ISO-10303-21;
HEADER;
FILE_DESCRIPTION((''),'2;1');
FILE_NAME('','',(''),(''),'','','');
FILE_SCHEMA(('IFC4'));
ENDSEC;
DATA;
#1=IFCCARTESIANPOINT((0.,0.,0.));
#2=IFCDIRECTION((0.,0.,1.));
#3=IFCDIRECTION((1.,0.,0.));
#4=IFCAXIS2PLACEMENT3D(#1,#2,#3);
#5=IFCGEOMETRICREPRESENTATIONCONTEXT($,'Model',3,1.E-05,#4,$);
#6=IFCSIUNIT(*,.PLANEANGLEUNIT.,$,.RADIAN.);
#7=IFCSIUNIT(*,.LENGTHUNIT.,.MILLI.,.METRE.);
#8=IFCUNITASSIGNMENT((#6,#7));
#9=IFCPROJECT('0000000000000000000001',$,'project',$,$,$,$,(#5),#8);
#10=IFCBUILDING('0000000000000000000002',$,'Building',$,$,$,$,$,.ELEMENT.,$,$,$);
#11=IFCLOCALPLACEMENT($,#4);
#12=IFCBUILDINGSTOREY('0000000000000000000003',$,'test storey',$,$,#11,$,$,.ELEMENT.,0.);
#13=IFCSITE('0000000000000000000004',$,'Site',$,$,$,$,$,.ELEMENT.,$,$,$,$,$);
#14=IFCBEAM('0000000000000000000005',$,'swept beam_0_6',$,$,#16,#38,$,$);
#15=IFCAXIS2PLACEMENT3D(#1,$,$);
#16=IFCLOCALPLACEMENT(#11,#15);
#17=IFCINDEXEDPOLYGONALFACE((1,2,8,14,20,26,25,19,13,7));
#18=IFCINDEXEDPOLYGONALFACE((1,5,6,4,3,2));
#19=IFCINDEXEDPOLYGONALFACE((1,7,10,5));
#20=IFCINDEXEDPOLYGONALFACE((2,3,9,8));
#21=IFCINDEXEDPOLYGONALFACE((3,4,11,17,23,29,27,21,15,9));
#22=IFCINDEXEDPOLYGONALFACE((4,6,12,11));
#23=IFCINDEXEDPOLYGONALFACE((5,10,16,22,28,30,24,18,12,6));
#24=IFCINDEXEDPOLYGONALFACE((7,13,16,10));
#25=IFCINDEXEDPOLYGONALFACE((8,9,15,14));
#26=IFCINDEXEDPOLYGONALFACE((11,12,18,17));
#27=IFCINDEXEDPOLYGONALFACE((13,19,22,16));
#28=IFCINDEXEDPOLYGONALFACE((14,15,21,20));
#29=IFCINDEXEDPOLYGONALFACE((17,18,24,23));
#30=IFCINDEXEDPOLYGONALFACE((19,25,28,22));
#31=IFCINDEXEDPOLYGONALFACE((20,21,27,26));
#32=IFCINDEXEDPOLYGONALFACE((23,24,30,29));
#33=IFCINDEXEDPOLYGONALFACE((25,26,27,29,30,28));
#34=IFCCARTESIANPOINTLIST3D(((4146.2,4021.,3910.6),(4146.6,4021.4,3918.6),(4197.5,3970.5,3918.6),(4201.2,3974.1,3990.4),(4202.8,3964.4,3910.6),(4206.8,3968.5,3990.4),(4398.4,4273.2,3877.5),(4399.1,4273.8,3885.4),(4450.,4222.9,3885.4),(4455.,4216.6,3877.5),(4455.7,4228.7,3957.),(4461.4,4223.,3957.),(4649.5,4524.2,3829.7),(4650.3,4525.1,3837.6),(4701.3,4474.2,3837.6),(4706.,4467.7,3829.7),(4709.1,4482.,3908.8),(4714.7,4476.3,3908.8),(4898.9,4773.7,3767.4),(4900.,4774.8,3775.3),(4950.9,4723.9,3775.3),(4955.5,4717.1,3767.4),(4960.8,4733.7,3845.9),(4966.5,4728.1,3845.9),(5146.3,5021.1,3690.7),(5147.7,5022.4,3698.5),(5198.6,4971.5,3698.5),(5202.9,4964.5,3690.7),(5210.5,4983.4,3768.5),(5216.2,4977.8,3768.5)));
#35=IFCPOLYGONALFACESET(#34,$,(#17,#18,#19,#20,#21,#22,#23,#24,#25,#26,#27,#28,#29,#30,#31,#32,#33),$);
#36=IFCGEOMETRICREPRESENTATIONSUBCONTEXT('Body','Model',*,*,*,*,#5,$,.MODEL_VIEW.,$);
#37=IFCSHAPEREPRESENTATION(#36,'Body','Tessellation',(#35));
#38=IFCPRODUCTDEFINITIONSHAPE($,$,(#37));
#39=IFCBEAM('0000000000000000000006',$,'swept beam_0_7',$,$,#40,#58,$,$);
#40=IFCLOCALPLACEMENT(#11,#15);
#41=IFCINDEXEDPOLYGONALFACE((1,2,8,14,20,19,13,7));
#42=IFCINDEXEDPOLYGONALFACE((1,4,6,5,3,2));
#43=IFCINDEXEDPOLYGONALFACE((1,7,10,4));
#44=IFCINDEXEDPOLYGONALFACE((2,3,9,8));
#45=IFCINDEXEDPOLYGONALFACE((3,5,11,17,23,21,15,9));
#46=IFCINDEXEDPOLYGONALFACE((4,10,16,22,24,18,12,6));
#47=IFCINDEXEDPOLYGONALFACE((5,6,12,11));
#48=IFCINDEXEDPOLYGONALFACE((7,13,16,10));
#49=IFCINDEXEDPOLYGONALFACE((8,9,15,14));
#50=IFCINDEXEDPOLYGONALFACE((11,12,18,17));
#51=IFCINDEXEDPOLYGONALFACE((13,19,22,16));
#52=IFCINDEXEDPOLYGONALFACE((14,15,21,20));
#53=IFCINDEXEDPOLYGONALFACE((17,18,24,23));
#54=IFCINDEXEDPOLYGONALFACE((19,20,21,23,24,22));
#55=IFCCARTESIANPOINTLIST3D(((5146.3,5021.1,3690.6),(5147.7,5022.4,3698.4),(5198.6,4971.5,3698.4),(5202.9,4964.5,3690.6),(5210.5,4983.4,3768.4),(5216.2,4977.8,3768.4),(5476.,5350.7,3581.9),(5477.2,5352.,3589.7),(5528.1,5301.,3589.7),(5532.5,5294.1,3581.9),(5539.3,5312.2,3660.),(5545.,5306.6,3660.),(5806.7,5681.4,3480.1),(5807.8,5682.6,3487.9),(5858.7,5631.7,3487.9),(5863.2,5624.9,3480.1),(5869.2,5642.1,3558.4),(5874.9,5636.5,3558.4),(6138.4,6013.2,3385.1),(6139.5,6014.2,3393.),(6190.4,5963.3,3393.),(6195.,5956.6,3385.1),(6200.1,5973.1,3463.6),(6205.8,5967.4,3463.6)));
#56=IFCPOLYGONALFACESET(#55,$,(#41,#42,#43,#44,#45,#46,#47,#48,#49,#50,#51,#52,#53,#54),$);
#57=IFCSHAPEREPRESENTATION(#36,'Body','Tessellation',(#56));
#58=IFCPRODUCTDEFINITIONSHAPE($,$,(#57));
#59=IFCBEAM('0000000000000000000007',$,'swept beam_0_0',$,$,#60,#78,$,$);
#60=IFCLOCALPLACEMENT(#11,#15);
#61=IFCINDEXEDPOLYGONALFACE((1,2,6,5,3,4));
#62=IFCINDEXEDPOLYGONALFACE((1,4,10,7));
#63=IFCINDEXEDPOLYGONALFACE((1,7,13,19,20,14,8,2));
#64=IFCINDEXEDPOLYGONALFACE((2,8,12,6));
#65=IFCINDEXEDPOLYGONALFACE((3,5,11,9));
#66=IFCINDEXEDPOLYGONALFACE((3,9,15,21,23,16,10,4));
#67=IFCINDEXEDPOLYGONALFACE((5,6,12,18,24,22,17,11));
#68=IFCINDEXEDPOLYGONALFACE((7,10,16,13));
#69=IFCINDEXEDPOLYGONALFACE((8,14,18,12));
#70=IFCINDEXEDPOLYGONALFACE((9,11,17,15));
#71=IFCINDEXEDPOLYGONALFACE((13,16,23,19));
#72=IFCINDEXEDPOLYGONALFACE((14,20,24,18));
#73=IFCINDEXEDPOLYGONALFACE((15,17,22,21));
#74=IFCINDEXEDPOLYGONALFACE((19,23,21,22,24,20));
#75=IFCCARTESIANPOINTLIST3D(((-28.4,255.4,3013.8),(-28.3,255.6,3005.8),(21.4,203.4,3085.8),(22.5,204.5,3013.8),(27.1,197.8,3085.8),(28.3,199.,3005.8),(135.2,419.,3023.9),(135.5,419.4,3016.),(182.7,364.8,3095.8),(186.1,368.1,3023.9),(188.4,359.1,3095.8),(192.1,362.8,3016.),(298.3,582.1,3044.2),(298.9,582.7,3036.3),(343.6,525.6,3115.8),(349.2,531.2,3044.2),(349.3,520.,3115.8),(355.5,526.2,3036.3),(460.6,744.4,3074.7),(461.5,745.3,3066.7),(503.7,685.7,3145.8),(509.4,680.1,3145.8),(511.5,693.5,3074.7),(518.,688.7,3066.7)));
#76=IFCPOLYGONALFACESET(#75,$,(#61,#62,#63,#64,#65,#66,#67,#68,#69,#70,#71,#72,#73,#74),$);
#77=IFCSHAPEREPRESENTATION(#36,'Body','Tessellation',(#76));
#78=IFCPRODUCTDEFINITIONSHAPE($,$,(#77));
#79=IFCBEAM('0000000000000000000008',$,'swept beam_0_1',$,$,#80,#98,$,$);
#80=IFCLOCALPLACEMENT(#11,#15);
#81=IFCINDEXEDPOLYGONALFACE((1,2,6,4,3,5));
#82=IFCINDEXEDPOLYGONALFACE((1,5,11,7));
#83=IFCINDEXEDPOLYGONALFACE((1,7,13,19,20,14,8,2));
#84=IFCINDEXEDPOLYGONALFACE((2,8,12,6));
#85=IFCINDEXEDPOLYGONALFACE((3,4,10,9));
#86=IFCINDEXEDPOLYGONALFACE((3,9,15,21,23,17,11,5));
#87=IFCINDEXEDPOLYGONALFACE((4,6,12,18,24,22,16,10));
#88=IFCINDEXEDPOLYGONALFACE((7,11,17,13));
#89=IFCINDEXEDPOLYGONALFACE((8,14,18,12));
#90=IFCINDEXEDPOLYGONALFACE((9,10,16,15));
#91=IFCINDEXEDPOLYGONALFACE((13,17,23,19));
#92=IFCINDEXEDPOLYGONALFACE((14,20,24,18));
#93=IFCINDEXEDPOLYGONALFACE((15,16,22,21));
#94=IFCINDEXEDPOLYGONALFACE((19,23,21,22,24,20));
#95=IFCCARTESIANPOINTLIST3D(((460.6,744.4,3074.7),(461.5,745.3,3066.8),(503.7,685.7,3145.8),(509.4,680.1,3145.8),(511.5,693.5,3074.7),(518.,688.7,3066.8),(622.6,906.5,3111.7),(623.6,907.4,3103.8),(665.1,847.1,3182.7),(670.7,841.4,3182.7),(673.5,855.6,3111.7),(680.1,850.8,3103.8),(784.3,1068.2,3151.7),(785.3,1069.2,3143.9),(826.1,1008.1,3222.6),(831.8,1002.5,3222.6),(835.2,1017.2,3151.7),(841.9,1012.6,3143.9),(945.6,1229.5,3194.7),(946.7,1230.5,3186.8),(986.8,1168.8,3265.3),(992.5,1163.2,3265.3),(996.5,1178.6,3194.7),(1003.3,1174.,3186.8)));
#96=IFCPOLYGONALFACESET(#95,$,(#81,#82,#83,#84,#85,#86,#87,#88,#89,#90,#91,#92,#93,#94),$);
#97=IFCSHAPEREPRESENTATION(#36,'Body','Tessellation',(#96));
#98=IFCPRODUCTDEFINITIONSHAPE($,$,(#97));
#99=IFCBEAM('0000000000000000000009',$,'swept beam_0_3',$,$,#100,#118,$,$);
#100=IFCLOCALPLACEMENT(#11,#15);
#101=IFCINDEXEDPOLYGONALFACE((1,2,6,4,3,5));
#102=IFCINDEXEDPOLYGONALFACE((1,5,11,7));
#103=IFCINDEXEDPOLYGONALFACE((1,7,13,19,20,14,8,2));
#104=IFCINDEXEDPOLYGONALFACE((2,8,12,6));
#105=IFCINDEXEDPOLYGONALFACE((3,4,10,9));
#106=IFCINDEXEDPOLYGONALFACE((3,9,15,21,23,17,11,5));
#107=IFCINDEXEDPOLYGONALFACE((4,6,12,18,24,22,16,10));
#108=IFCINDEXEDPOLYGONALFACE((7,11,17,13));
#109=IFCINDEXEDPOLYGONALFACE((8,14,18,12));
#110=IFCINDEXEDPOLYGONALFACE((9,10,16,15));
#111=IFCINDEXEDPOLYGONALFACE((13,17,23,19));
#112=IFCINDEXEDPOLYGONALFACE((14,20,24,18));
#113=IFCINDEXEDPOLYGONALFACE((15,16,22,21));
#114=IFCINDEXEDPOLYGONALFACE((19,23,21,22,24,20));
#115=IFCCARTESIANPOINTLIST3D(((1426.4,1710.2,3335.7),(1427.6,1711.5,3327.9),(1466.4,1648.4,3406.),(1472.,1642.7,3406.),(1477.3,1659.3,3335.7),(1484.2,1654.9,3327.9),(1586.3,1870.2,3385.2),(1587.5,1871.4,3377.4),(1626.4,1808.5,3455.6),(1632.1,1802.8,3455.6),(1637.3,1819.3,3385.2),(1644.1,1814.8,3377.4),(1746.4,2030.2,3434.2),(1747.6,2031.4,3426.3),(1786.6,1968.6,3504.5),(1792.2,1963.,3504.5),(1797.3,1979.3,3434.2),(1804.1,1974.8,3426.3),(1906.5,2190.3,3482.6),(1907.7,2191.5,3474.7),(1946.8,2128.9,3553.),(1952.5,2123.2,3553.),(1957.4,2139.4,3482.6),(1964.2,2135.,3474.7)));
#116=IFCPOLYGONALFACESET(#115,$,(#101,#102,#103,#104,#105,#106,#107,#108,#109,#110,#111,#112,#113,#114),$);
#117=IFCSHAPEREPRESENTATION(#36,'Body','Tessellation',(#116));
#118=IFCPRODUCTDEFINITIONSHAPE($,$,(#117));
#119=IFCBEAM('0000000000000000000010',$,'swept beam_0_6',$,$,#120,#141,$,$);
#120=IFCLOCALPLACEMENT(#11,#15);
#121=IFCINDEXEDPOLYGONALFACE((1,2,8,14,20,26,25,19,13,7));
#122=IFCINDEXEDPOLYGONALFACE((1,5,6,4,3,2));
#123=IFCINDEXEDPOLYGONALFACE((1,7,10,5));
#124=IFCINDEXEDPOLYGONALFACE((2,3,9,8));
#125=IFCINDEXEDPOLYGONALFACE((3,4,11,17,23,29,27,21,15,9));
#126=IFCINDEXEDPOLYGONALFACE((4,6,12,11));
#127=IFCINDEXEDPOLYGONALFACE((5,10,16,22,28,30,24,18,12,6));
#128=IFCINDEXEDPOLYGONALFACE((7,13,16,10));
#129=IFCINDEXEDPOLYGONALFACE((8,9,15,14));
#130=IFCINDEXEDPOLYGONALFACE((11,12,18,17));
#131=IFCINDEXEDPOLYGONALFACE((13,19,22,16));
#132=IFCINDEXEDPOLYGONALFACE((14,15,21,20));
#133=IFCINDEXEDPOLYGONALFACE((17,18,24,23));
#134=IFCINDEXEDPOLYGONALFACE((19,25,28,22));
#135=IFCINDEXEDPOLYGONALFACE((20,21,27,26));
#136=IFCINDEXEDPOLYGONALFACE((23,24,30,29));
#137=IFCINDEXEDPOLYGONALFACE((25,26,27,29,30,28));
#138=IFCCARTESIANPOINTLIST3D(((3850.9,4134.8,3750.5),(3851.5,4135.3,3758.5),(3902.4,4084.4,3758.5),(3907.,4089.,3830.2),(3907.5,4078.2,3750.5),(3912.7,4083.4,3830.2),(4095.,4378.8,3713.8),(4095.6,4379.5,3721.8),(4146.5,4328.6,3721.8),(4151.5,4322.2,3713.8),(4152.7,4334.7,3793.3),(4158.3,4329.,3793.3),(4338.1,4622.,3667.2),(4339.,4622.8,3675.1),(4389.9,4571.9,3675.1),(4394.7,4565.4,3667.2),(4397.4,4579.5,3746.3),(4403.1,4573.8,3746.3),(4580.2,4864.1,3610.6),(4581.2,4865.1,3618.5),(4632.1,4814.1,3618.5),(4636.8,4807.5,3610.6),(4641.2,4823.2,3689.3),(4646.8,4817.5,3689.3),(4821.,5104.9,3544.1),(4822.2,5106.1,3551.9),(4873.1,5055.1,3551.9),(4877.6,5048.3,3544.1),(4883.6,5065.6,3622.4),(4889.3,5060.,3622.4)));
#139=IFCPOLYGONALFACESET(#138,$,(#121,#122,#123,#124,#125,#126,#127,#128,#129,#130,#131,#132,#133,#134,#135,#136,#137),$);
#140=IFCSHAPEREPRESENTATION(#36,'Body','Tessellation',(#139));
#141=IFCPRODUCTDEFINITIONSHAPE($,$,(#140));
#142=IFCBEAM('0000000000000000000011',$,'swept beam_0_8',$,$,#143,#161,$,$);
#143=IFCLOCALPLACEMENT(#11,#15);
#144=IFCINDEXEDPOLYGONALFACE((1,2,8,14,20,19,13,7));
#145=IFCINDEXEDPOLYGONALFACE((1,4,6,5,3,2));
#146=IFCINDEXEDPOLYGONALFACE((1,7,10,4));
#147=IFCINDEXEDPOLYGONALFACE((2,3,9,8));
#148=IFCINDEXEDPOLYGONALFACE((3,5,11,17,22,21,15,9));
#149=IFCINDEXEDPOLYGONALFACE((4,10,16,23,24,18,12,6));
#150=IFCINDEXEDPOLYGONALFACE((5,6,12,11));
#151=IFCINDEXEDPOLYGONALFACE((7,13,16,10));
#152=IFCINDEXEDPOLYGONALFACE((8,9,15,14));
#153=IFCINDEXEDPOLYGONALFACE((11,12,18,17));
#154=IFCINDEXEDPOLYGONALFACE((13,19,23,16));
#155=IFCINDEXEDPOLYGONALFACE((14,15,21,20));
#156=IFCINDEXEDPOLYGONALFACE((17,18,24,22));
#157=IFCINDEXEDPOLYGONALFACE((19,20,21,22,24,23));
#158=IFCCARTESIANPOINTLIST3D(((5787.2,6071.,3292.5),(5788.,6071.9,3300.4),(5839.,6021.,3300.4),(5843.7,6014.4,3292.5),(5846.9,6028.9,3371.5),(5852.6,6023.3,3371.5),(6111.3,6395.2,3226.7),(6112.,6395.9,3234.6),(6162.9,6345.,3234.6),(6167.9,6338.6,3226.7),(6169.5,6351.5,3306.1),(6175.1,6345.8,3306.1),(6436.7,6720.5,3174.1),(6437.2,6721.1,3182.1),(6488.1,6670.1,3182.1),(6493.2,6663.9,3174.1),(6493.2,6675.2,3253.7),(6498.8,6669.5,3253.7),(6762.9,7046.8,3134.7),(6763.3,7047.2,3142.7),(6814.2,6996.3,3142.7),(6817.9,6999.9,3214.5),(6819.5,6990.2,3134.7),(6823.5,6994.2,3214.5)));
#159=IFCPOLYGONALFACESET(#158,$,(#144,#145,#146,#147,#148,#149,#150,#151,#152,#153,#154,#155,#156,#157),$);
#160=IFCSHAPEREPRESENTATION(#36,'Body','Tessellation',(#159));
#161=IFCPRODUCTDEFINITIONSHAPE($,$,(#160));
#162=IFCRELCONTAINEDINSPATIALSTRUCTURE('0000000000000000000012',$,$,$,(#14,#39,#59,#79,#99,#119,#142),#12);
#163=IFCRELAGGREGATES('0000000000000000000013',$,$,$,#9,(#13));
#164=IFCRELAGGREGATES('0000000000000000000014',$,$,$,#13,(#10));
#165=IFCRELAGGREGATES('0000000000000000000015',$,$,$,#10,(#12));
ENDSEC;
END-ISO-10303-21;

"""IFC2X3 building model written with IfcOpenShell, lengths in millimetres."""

from ifc_helpers import new_model, entity, si_unit, origin_with_axes, place, context, subcontext, project, spatial, element, save


model = new_model("IFC2X3")

# Units and contexts
model_context = context("Model", 3, precision=1e-05, world=origin_with_axes())
body_context = subcontext(model_context, "Body", "Model", "MODEL_VIEW")
ifc_project = project(units=[si_unit("PLANEANGLEUNIT", "RADIAN"), si_unit("LENGTHUNIT", "METRE", prefix="MILLI")], contexts=[model_context])

# Site, building, storey
site = spatial("IfcSite", under=ifc_project, Name="Site", CompositionType="ELEMENT")
building = spatial("IfcBuilding", under=site, Name="Building", CompositionType="ELEMENT")
storey_placement = place(None, origin_with_axes())
storey = spatial("IfcBuildingStorey", under=building, at=storey_placement, Name="test storey", CompositionType="ELEMENT", Elevation=0.0)

# Beams
beam_1_placement = place(storey_placement, origin_with_axes())
element("IfcBeam", 1, at=beam_1_placement, inside=storey, Name="swept beam_0_6", context=body_context, shape_type="SweptSolid", body=[
    entity("IfcRevolvedAreaSolid", entity("IfcArbitraryClosedProfileDef", "AREA", None, entity("IfcPolyline", [entity("IfcCartesianPoint", [80.0, -40.0]), entity("IfcCartesianPoint", [80.0, -32.0]), entity("IfcCartesianPoint", [8.0, -32.0]), entity("IfcCartesianPoint", [8.0, 40.0]), entity("IfcCartesianPoint", [0.0, 40.0]), entity("IfcCartesianPoint", [0.0, -40.0]), entity("IfcCartesianPoint", [80.0, -40.0])])), entity("IfcAxis2Placement3D", entity("IfcCartesianPoint", [4174.5, 3992.7, 3910.6]), entity("IfcDirection", [-0.7053, -0.7053, 0.072]), entity("IfcDirection", [0.0509, 0.0509, 0.9974])), entity("IfcAxis1Placement", entity("IfcCartesianPoint", [-8719.6, 0.0, 0.0]), entity("IfcDirection", [0.0, 1.0, 0.0])), 0.164343),
])
beam_2_placement = place(storey_placement, origin_with_axes())
element("IfcBeam", 2, at=beam_2_placement, inside=storey, Name="swept beam_0_7", context=body_context, shape_type="SweptSolid", body=[
    entity("IfcRevolvedAreaSolid", entity("IfcArbitraryClosedProfileDef", "AREA", None, entity("IfcPolyline", [entity("IfcCartesianPoint", [-80.0, 40.0]), entity("IfcCartesianPoint", [-80.0, 32.0]), entity("IfcCartesianPoint", [-8.0, 32.0]), entity("IfcCartesianPoint", [-8.0, -40.0]), entity("IfcCartesianPoint", [0.0, -40.0]), entity("IfcCartesianPoint", [0.0, 40.0]), entity("IfcCartesianPoint", [-80.0, 40.0])])), entity("IfcAxis2Placement3D", entity("IfcCartesianPoint", [5174.6, 4992.8, 3690.6]), entity("IfcDirection", [-0.6874, -0.6874, 0.2342]), entity("IfcDirection", [-0.1656, -0.1656, -0.9722])), entity("IfcAxis1Placement", entity("IfcCartesianPoint", [-32664.4, 0.0, 0.0]), entity("IfcDirection", [0.0, 1.0, 0.0])), 0.043962),
])
beam_3_placement = place(storey_placement, origin_with_axes())
element("IfcBeam", 3, at=beam_3_placement, inside=storey, Name="swept beam_0_0", context=body_context, shape_type="SweptSolid", body=[
    entity("IfcRevolvedAreaSolid", entity("IfcArbitraryClosedProfileDef", "AREA", None, entity("IfcPolyline", [entity("IfcCartesianPoint", [-80.0, 40.0]), entity("IfcCartesianPoint", [-80.0, 32.0]), entity("IfcCartesianPoint", [-8.0, 32.0]), entity("IfcCartesianPoint", [-8.0, -40.0]), entity("IfcCartesianPoint", [0.0, -40.0]), entity("IfcCartesianPoint", [0.0, 40.0]), entity("IfcCartesianPoint", [-80.0, 40.0])])), entity("IfcAxis2Placement3D", entity("IfcCartesianPoint", [0.0, 227.3, 3005.8]), entity("IfcDirection", [-0.7069, -0.7069, -0.0216]), entity("IfcDirection", [0.0153, 0.0153, -0.9998])), entity("IfcAxis1Placement", entity("IfcCartesianPoint", [-5261.2, 0.0, 0.0]), entity("IfcDirection", [0.0, 1.0, 0.0])), 0.132247),
])
beam_4_placement = place(storey_placement, origin_with_axes())
element("IfcBeam", 4, at=beam_4_placement, inside=storey, Name="swept beam_0_1", context=body_context, shape_type="SweptSolid", body=[
    entity("IfcRevolvedAreaSolid", entity("IfcArbitraryClosedProfileDef", "AREA", None, entity("IfcPolyline", [entity("IfcCartesianPoint", [-80.0, 40.0]), entity("IfcCartesianPoint", [-80.0, 32.0]), entity("IfcCartesianPoint", [-8.0, 32.0]), entity("IfcCartesianPoint", [-8.0, -40.0]), entity("IfcCartesianPoint", [0.0, -40.0]), entity("IfcCartesianPoint", [0.0, 40.0]), entity("IfcCartesianPoint", [-80.0, 40.0])])), entity("IfcAxis2Placement3D", entity("IfcCartesianPoint", [489.7, 717.0, 3066.8]), entity("IfcDirection", [-0.6988, -0.6988, -0.1533]), entity("IfcDirection", [0.1084, 0.1084, -0.9882])), entity("IfcAxis1Placement", entity("IfcCartesianPoint", [-18065.0, 0.0, 0.0]), entity("IfcDirection", [0.0, 1.0, 0.0])), 0.038567),
])
beam_5_placement = place(storey_placement, origin_with_axes())
element("IfcBeam", 5, at=beam_5_placement, inside=storey, Name="swept beam_0_3", context=body_context, shape_type="SweptSolid", body=[
    entity("IfcRevolvedAreaSolid", entity("IfcArbitraryClosedProfileDef", "AREA", None, entity("IfcPolyline", [entity("IfcCartesianPoint", [80.0, -40.0]), entity("IfcCartesianPoint", [80.0, -32.0]), entity("IfcCartesianPoint", [8.0, -32.0]), entity("IfcCartesianPoint", [8.0, 40.0]), entity("IfcCartesianPoint", [0.0, 40.0]), entity("IfcCartesianPoint", [0.0, -40.0]), entity("IfcCartesianPoint", [80.0, -40.0])])), entity("IfcAxis2Placement3D", entity("IfcCartesianPoint", [1455.9, 1683.2, 3327.9]), entity("IfcDirection", [-0.6906, -0.6906, -0.215]), entity("IfcDirection", [-0.152, -0.152, 0.9766])), entity("IfcAxis1Placement", entity("IfcCartesianPoint", [-94832.6, 0.0, 0.0]), entity("IfcDirection", [0.0, 1.0, 0.0])), 0.007325),
])
beam_6_placement = place(storey_placement, origin_with_axes())
element("IfcBeam", 6, at=beam_6_placement, inside=storey, Name="swept beam_0_6", context=body_context, shape_type="SweptSolid", body=[
    entity("IfcRevolvedAreaSolid", entity("IfcArbitraryClosedProfileDef", "AREA", None, entity("IfcPolyline", [entity("IfcCartesianPoint", [80.0, -40.0]), entity("IfcCartesianPoint", [80.0, -32.0]), entity("IfcCartesianPoint", [8.0, -32.0]), entity("IfcCartesianPoint", [8.0, 40.0]), entity("IfcCartesianPoint", [0.0, 40.0]), entity("IfcCartesianPoint", [0.0, -40.0]), entity("IfcCartesianPoint", [80.0, -40.0])])), entity("IfcAxis2Placement3D", entity("IfcCartesianPoint", [3879.2, 4106.5, 3750.5]), entity("IfcDirection", [-0.7042, -0.7042, 0.0912]), entity("IfcDirection", [0.0645, 0.0645, 0.9958])), entity("IfcAxis1Placement", entity("IfcCartesianPoint", [-11962.2, 0.0, 0.0]), entity("IfcDirection", [0.0, 1.0, 0.0])), 0.116045),
])
beam_7_placement = place(storey_placement, origin_with_axes())
element("IfcBeam", 7, at=beam_7_placement, inside=storey, Name="swept beam_0_8", context=body_context, shape_type="SweptSolid", body=[
    entity("IfcRevolvedAreaSolid", entity("IfcArbitraryClosedProfileDef", "AREA", None, entity("IfcPolyline", [entity("IfcCartesianPoint", [-80.0, 40.0]), entity("IfcCartesianPoint", [-80.0, 32.0]), entity("IfcCartesianPoint", [-8.0, 32.0]), entity("IfcCartesianPoint", [-8.0, -40.0]), entity("IfcCartesianPoint", [0.0, -40.0]), entity("IfcCartesianPoint", [0.0, 40.0]), entity("IfcCartesianPoint", [-80.0, 40.0])])), entity("IfcAxis2Placement3D", entity("IfcCartesianPoint", [5815.4, 6042.7, 3292.5]), entity("IfcDirection", [-0.6984, -0.6984, 0.1562]), entity("IfcDirection", [-0.1105, -0.1105, -0.9877])), entity("IfcAxis1Placement", entity("IfcCartesianPoint", [-16161.1, 0.0, 0.0]), entity("IfcDirection", [0.0, 1.0, 0.0])), 0.08597),
])

save(model, "model.ifc")
